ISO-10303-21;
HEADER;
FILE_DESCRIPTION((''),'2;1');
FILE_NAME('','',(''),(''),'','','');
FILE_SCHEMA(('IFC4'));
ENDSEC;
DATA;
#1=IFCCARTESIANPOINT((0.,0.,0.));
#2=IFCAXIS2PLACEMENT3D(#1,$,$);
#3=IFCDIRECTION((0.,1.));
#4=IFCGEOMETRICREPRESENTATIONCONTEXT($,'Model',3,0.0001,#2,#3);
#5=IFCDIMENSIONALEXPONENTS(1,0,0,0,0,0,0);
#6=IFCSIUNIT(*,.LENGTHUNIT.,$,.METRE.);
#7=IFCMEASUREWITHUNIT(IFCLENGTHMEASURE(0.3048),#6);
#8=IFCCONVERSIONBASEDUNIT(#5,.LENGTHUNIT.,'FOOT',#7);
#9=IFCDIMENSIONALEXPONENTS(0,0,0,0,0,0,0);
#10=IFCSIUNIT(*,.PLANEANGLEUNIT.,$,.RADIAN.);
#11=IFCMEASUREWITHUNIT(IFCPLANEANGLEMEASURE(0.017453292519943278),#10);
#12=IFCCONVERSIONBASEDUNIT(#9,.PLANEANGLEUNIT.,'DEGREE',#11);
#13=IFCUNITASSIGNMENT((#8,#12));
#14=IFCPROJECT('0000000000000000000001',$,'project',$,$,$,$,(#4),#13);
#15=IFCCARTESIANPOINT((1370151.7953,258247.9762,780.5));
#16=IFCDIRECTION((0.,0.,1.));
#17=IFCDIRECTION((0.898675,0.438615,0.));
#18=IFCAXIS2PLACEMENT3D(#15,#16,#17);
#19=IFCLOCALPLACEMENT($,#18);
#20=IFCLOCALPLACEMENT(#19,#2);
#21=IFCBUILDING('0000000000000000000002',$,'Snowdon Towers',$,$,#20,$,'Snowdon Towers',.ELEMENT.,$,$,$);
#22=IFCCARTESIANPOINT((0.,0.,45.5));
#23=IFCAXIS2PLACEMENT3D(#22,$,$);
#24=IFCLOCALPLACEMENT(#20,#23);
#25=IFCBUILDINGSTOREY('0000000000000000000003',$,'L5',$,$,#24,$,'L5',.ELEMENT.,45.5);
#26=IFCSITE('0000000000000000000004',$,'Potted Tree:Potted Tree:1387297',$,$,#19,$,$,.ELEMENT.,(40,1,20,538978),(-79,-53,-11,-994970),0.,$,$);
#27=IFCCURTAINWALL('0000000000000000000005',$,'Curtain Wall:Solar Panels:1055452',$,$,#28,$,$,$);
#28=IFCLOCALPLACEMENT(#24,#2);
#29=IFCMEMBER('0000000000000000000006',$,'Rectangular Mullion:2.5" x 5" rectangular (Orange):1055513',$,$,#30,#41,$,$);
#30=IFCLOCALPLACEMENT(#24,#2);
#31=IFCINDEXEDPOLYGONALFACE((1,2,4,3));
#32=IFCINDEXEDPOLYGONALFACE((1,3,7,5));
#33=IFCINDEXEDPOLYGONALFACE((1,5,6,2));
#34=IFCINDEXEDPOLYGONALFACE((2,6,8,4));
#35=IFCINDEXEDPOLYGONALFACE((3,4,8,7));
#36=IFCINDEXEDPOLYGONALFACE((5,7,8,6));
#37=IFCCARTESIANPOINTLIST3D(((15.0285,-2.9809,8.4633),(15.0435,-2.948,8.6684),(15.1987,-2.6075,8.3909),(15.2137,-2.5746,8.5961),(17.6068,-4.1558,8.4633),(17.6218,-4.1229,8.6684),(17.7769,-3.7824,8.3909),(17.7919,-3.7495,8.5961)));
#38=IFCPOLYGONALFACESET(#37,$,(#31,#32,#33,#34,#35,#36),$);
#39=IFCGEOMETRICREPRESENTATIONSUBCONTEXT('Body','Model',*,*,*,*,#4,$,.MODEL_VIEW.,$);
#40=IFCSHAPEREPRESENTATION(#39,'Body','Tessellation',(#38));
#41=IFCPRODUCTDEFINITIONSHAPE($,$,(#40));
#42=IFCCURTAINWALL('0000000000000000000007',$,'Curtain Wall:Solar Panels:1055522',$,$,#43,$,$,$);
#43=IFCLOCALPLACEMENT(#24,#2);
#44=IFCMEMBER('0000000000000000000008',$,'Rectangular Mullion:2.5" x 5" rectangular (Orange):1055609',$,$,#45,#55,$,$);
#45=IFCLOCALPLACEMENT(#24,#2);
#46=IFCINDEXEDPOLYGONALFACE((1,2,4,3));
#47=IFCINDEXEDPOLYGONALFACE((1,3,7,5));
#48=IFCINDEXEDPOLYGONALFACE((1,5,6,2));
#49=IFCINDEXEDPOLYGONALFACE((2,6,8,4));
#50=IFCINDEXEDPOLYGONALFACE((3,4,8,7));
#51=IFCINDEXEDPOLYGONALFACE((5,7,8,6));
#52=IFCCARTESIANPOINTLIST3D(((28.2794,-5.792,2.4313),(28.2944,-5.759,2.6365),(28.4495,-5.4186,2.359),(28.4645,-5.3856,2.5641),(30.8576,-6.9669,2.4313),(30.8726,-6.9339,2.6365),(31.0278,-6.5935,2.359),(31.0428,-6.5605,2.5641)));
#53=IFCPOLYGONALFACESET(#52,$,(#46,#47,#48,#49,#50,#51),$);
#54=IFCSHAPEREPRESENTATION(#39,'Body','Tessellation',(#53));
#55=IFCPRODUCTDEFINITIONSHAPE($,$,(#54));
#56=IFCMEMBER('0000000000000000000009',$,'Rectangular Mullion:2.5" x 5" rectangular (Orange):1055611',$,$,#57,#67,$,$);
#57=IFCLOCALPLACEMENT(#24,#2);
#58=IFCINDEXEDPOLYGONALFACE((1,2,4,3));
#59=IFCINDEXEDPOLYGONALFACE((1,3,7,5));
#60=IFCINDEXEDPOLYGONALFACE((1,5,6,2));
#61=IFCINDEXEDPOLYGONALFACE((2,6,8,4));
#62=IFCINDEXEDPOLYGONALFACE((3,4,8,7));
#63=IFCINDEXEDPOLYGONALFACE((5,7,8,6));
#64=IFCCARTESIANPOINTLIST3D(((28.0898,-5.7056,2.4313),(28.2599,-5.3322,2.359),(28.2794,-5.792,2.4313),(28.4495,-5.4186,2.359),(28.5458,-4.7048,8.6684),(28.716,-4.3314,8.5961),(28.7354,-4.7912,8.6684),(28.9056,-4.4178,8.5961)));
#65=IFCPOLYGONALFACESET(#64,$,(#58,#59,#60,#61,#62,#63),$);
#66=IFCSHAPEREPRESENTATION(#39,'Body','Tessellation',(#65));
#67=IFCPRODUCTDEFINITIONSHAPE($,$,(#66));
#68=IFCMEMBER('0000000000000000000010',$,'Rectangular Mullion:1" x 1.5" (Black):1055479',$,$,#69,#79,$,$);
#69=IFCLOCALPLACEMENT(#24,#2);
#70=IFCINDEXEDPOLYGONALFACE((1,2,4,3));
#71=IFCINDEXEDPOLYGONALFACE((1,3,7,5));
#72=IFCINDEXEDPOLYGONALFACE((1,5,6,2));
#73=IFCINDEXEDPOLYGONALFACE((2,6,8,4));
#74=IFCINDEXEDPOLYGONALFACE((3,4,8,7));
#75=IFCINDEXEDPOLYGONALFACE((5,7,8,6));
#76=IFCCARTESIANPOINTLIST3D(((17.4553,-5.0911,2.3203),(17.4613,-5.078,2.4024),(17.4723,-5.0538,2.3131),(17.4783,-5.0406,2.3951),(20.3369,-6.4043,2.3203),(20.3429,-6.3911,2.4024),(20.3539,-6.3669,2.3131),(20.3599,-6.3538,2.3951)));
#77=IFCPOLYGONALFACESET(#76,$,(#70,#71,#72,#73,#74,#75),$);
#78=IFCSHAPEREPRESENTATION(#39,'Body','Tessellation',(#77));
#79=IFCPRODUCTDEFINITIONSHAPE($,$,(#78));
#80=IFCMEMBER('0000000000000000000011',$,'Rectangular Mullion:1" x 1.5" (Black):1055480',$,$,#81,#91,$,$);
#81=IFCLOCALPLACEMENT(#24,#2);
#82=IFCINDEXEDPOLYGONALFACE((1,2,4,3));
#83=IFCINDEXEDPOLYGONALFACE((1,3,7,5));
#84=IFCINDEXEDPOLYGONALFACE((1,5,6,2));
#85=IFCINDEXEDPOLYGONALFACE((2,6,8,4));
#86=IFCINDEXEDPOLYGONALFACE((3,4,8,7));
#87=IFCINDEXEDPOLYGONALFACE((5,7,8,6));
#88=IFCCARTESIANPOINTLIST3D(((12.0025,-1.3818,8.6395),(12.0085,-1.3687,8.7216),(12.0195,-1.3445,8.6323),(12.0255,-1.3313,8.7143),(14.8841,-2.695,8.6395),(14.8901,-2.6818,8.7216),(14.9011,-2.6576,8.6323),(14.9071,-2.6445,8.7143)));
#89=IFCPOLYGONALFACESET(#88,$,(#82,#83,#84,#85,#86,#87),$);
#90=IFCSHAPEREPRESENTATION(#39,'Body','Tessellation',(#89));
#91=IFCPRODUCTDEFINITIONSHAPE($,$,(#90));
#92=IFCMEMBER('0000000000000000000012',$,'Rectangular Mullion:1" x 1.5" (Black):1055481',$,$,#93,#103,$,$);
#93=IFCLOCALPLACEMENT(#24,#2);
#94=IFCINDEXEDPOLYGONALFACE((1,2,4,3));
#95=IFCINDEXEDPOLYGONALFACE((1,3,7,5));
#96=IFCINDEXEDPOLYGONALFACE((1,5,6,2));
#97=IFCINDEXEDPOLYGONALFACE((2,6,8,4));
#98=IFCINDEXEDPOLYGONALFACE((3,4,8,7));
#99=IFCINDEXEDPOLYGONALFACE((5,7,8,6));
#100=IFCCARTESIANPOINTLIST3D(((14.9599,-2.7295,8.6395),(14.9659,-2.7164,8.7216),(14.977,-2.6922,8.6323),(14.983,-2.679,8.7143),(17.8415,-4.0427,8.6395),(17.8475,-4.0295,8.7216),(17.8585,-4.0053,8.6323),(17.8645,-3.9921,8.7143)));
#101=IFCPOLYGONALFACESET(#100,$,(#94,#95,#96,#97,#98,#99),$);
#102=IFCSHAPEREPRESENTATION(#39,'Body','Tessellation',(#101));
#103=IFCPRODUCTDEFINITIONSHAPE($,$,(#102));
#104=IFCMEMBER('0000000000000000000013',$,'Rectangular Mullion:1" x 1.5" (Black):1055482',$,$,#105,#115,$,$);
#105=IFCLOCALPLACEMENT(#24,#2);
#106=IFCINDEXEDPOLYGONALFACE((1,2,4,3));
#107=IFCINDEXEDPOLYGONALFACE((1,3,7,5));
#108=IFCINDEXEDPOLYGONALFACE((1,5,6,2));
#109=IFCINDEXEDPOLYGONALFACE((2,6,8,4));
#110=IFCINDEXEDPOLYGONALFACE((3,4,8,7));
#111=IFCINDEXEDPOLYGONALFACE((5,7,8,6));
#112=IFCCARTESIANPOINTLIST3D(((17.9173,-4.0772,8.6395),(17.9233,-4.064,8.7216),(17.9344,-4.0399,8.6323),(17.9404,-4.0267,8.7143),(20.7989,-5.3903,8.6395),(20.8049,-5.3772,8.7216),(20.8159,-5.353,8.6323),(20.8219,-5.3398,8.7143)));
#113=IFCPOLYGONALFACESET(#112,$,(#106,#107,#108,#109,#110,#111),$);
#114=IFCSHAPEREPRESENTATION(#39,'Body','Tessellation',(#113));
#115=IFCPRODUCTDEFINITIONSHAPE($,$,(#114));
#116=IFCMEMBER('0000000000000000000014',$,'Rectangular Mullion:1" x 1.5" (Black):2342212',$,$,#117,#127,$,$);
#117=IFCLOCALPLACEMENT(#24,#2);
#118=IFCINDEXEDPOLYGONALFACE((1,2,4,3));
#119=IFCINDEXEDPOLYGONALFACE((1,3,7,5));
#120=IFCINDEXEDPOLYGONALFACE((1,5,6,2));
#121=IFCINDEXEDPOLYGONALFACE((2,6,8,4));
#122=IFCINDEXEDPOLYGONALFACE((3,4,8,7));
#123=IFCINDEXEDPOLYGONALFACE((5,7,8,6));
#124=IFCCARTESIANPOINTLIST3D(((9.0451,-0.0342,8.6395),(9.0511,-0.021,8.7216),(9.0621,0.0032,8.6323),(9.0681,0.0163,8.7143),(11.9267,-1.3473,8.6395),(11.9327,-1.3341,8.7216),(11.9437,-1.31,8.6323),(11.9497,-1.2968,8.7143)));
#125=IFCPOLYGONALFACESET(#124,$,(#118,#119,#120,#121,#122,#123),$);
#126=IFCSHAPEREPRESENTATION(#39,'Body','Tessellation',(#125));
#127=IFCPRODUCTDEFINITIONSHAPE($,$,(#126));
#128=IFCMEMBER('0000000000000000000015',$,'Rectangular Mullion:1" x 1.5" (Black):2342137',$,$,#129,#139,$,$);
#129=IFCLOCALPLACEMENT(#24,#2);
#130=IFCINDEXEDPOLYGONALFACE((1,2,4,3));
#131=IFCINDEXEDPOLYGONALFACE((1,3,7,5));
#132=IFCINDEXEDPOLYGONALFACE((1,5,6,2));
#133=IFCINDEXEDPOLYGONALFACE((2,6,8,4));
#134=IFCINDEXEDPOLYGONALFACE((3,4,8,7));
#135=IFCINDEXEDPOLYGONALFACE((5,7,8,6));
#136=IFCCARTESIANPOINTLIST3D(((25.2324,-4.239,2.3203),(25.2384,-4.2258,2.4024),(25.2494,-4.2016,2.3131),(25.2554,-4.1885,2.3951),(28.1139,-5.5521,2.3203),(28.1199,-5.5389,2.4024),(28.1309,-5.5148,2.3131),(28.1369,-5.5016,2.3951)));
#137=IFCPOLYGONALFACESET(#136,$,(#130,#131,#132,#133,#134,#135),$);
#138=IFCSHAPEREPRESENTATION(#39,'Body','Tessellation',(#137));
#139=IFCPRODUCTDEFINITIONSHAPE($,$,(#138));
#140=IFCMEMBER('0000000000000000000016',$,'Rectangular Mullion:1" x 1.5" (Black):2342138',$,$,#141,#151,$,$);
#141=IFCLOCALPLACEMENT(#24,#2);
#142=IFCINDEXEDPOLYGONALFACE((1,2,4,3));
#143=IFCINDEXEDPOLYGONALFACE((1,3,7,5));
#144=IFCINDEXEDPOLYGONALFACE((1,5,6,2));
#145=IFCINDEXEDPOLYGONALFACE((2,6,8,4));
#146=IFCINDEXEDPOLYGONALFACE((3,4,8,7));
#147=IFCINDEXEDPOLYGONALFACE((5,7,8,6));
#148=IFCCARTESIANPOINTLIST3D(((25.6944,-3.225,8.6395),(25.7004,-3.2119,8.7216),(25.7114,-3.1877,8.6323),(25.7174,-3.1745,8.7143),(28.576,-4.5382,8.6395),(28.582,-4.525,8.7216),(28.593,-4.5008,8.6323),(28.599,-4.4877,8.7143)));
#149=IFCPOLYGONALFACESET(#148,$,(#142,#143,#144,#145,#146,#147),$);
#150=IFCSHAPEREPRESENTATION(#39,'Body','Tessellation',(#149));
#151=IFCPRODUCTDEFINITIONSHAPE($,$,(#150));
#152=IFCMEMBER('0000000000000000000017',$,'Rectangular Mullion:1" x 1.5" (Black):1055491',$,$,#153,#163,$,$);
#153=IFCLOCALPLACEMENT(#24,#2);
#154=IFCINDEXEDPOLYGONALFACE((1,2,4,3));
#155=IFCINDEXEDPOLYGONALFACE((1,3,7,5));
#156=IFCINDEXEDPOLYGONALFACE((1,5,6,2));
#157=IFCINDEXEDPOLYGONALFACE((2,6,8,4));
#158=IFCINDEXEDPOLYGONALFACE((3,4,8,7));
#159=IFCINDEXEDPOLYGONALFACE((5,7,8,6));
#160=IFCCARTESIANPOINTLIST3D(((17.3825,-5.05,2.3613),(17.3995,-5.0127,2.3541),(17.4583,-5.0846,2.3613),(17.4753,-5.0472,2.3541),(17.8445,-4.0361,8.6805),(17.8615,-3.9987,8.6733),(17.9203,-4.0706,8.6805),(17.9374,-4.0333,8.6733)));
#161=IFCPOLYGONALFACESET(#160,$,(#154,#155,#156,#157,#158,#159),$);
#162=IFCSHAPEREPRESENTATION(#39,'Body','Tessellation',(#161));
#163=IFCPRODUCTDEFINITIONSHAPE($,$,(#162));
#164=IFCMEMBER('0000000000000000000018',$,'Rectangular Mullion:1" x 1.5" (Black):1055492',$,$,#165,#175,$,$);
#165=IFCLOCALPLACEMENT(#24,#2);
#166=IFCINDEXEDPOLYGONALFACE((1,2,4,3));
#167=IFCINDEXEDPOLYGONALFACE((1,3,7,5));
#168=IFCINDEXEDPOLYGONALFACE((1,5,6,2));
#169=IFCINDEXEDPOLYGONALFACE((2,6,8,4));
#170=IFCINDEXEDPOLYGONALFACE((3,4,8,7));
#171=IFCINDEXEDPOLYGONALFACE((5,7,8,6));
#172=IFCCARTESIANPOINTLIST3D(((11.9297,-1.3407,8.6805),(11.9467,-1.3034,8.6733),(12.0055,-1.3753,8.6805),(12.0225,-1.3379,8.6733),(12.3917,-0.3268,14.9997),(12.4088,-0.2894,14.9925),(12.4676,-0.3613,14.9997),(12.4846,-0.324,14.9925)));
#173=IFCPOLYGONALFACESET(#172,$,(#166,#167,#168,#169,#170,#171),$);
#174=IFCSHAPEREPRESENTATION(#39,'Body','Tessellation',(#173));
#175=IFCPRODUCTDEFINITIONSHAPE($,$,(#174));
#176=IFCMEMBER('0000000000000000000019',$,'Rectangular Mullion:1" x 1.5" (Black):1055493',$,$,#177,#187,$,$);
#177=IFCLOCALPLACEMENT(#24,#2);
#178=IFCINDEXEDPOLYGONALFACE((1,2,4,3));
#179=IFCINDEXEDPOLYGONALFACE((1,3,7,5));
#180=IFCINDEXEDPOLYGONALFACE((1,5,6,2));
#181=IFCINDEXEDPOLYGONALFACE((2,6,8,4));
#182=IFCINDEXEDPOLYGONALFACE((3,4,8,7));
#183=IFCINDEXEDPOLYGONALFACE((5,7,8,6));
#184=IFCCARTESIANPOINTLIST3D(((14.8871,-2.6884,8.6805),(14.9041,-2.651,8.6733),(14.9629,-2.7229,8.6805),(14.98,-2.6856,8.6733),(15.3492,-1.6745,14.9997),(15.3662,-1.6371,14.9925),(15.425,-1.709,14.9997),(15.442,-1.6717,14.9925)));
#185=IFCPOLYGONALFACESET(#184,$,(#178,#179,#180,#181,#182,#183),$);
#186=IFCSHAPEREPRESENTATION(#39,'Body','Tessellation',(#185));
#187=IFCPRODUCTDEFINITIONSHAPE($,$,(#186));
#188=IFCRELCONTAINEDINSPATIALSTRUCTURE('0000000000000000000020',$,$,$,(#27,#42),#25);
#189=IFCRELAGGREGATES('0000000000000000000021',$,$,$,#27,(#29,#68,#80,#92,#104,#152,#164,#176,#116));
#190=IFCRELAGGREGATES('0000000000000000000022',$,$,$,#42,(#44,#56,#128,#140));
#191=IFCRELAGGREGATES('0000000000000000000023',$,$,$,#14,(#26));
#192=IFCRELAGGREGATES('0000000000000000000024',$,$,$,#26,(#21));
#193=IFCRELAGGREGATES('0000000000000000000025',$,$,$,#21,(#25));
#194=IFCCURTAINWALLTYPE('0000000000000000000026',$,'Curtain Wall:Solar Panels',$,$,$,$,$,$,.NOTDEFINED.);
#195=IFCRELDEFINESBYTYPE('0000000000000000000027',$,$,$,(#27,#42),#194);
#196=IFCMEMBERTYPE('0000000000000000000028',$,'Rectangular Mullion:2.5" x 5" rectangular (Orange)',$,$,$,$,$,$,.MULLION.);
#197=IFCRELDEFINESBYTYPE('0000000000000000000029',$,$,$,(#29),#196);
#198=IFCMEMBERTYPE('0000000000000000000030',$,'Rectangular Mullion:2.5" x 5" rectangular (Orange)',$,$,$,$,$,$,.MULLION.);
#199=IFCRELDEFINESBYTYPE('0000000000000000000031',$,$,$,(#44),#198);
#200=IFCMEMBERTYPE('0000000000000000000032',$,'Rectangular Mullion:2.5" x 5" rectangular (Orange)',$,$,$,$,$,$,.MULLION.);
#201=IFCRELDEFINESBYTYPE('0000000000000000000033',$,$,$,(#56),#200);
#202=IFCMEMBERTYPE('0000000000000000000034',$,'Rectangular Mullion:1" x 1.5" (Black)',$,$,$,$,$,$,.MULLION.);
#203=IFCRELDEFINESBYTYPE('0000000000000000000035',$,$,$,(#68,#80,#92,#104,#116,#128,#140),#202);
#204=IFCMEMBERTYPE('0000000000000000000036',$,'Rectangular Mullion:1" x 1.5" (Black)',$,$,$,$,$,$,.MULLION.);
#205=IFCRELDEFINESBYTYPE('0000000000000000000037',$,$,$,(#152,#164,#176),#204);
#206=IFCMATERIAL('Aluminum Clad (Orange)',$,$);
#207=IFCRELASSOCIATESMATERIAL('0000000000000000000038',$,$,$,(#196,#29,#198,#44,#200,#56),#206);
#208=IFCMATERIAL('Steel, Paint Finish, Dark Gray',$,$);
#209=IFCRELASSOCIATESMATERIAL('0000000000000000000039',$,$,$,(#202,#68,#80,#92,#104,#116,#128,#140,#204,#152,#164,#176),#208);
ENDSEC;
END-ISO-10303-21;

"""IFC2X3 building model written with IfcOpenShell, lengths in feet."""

from ifc_helpers import new_model, entity, si_unit, converted_unit, direction, frame, frame_2d, origin, origin_2d_with_axis, place, context, subcontext, project, spatial, rectangle, extrude, source, transform, mapped, material, type_object, type_shapes, element, aggregate, save


model = new_model("IFC2X3")

# Units and contexts
model_context = context("Model", 3, precision=0.0001, world=origin(), true_north=direction((0.0, 1.0)))
body_context = subcontext(model_context, "Body", "Model", "MODEL_VIEW")
ifc_project = project(units=[converted_unit("LENGTHUNIT", "FOOT", entity("IfcLengthMeasure", 0.3048), si_unit("LENGTHUNIT", "METRE"), dimensions=[1, 0, 0, 0, 0, 0, 0]), converted_unit("PLANEANGLEUNIT", "DEGREE", entity("IfcPlaneAngleMeasure", 0.017453292519943278), si_unit("PLANEANGLEUNIT", "RADIAN"), dimensions=[0, 0, 0, 0, 0, 0, 0])], contexts=[model_context])

# Site, building, storey
site_placement = place(None, frame((1370151.7953, 258247.9762, 780.5), z_axis=(0.0, 0.0, 1.0), x_axis=(0.898675, 0.438615, 0.0)))
site = spatial("IfcSite", under=ifc_project, at=site_placement, Name="Potted Tree:Potted Tree:1387297", CompositionType="ELEMENT", RefLatitude=(40, 1, 20, 538978), RefLongitude=(-79, -53, -11, -994970), RefElevation=0.0)
building_placement = place(site_placement, origin())
building = spatial("IfcBuilding", under=site, at=building_placement, Name="Snowdon Towers", LongName="Snowdon Towers", CompositionType="ELEMENT")
storey_placement = place(building_placement, frame((0.0, 0.0, 45.5)))
storey = spatial("IfcBuildingStorey", under=building, at=storey_placement, Name="L5", LongName="L5", CompositionType="ELEMENT", Elevation=45.5)

# Curtain wall, member
curtain_wall_type = type_object("IfcCurtainWallType", Name="Curtain Wall:Solar Panels", PredefinedType="NOTDEFINED")
curtain_wall_1_placement = place(storey_placement, frame((0.0, 0.0, -45.5)))
curtain_wall_1 = element("IfcCurtainWall", 1, at=curtain_wall_1_placement, inside=storey, type_object=curtain_wall_type, Name="Curtain Wall:Solar Panels:1055452")
ifc_material_1 = material(Name="Aluminum Clad (Orange)")
member_type_1 = type_object("IfcMemberType", Name="Rectangular Mullion:2.5\" x 5\" rectangular (Orange)", PredefinedType="MULLION", material=ifc_material_1)
shared_shape_1 = source(origin(), body_context, "Body", "SweptSolid", [
    extrude(rectangle(XDim=0.2083, YDim=0.4167, at=frame_2d((0.0, 0.0), x_axis=(1.0, 0.0))), frame((-0.1042, 0.0, -2.8333), z_axis=(0.0, 0.0, 1.0), x_axis=(-1.0, 0.0, 0.0)), (0.0, 0.0, 1.0), 2.8333),
])
type_shapes(member_type_1, [shared_shape_1])
member_1_placement = place(curtain_wall_1_placement, frame((17.7069, -3.9362, 54.1323), z_axis=(0.909972, -0.414671, 0.0), x_axis=(0.072007, 0.158015, 0.984808)))
member_1 = element("IfcMember", 2, at=member_1_placement, type_object=member_type_1, material=ifc_material_1, Name="Rectangular Mullion:2.5\" x 5\" rectangular (Orange):1055513", context=body_context, shape_type="MappedRepresentation", body=[
    mapped(shared_shape_1, transform((0.0, 0.0, 0.0), scale=1.0)),
])

# Curtain wall, members
curtain_wall_2_placement = place(storey_placement, frame((0.0, 0.0, -45.5)))
curtain_wall_2 = element("IfcCurtainWall", 3, at=curtain_wall_2_placement, inside=storey, type_object=curtain_wall_type, Name="Curtain Wall:Solar Panels:1055522")
member_type_2 = type_object("IfcMemberType", Name="Rectangular Mullion:2.5\" x 5\" rectangular (Orange)", PredefinedType="MULLION", material=ifc_material_1)
shared_shape_2 = source(origin(), body_context, "Body", "SweptSolid", [
    extrude(rectangle(XDim=0.2083, YDim=0.4167, at=frame_2d((0.0, 0.0), x_axis=(1.0, 0.0))), frame((-0.1042, 0.0, -2.8333), z_axis=(0.0, 0.0, 1.0), x_axis=(-1.0, 0.0, 0.0)), (0.0, 0.0, 1.0), 2.8333),
])
type_shapes(member_type_2, [shared_shape_2])
member_2_placement = place(curtain_wall_2_placement, frame((28.3644, -5.6053, 47.8951), z_axis=(-0.909972, 0.414671, 0.0), x_axis=(-0.072007, -0.158015, -0.984808)))
member_2 = element("IfcMember", 4, at=member_2_placement, type_object=member_type_2, material=ifc_material_1, Name="Rectangular Mullion:2.5\" x 5\" rectangular (Orange):1055609", context=body_context, shape_type="MappedRepresentation", body=[
    mapped(shared_shape_2, transform((0.0, 0.0, 0.0), scale=1.0)),
])
member_type_3 = type_object("IfcMemberType", Name="Rectangular Mullion:2.5\" x 5\" rectangular (Orange)", PredefinedType="MULLION", material=ifc_material_1)
shared_shape_3 = source(origin(), body_context, "Body", "SweptSolid", [
    extrude(rectangle(XDim=0.2083, YDim=0.4167, at=frame_2d((0.0, 0.0), x_axis=(1.0, 0.0))), frame((-0.1042, 0.0, -6.3333), z_axis=(0.0, 0.0, 1.0), x_axis=(-1.0, 0.0, 0.0)), (0.0, 0.0, 1.0), 6.3333),
])
type_shapes(member_type_3, [shared_shape_3])
member_3_placement = place(curtain_wall_2_placement, frame((28.6309, -4.5181, 54.1323), z_axis=(0.072007, 0.158015, 0.984808), x_axis=(-0.909972, 0.414671, 0.0)))
member_3 = element("IfcMember", 5, at=member_3_placement, type_object=member_type_3, material=ifc_material_1, Name="Rectangular Mullion:2.5\" x 5\" rectangular (Orange):1055611", context=body_context, shape_type="MappedRepresentation", body=[
    mapped(shared_shape_3, transform((0.0, 0.0, 0.0), scale=1.0)),
])

# Members
ifc_material_2 = material(Name="Steel, Paint Finish, Dark Gray")
member_type_4 = type_object("IfcMemberType", Name="Rectangular Mullion:1\" x 1.5\" (Black)", PredefinedType="MULLION", material=ifc_material_2)
shared_shape_4 = source(origin(), body_context, "Body", "SweptSolid", [
    extrude(rectangle(XDim=0.0833, YDim=0.0417, at=origin_2d_with_axis()), frame((0.0, 0.0208, -3.1667), z_axis=(0.0, 0.0, 1.0), x_axis=(-1.0, 0.0, 0.0)), (0.0, 0.0, 1.0), 3.1667),
])
type_shapes(member_type_4, [shared_shape_4])
member_4_placement = place(curtain_wall_1_placement, frame((20.3569, -6.3603, 47.8541), z_axis=(0.909972, -0.414671, 0.0), x_axis=(0.072007, 0.158015, 0.984808)))
member_4 = element("IfcMember", 6, at=member_4_placement, type_object=member_type_4, material=ifc_material_2, Name="Rectangular Mullion:1\" x 1.5\" (Black):1055479", context=body_context, shape_type="MappedRepresentation", body=[
    mapped(shared_shape_4, transform((0.0, 0.0, 0.0), scale=1.0)),
])
member_5_placement = place(curtain_wall_1_placement, frame((14.9041, -2.651, 54.1733), z_axis=(0.909972, -0.414671, 0.0), x_axis=(0.072007, 0.158015, 0.984808)))
member_5 = element("IfcMember", 7, at=member_5_placement, type_object=member_type_4, material=ifc_material_2, Name="Rectangular Mullion:1\" x 1.5\" (Black):1055480", context=body_context, shape_type="MappedRepresentation", body=[
    mapped(shared_shape_4, transform((0.0, 0.0, 0.0), scale=1.0)),
])
member_6_placement = place(curtain_wall_1_placement, frame((17.8615, -3.9987, 54.1733), z_axis=(0.909972, -0.414671, 0.0), x_axis=(0.072007, 0.158015, 0.984808)))
member_6 = element("IfcMember", 8, at=member_6_placement, type_object=member_type_4, material=ifc_material_2, Name="Rectangular Mullion:1\" x 1.5\" (Black):1055481", context=body_context, shape_type="MappedRepresentation", body=[
    mapped(shared_shape_4, transform((0.0, 0.0, 0.0), scale=1.0)),
])
member_7_placement = place(curtain_wall_1_placement, frame((20.8189, -5.3464, 54.1733), z_axis=(0.909972, -0.414671, 0.0), x_axis=(0.072007, 0.158015, 0.984808)))
member_7 = element("IfcMember", 9, at=member_7_placement, type_object=member_type_4, material=ifc_material_2, Name="Rectangular Mullion:1\" x 1.5\" (Black):1055482", context=body_context, shape_type="MappedRepresentation", body=[
    mapped(shared_shape_4, transform((0.0, 0.0, 0.0), scale=1.0)),
])
member_8_placement = place(curtain_wall_1_placement, frame((11.9467, -1.3034, 54.1733), z_axis=(0.909972, -0.414671, 0.0), x_axis=(0.072007, 0.158015, 0.984808)))
member_8 = element("IfcMember", 10, at=member_8_placement, type_object=member_type_4, material=ifc_material_2, Name="Rectangular Mullion:1\" x 1.5\" (Black):2342212", context=body_context, shape_type="MappedRepresentation", body=[
    mapped(shared_shape_4, transform((0.0, 0.0, 0.0), scale=1.0)),
])
member_9_placement = place(curtain_wall_2_placement, frame((28.1339, -5.5082, 47.8541), z_axis=(0.909972, -0.414671, 0.0), x_axis=(0.072007, 0.158015, 0.984808)))
member_9 = element("IfcMember", 11, at=member_9_placement, type_object=member_type_4, material=ifc_material_2, Name="Rectangular Mullion:1\" x 1.5\" (Black):2342137", context=body_context, shape_type="MappedRepresentation", body=[
    mapped(shared_shape_4, transform((0.0, 0.0, 0.0), scale=1.0)),
])
member_10_placement = place(curtain_wall_2_placement, frame((28.596, -4.4943, 54.1733), z_axis=(0.909972, -0.414671, 0.0), x_axis=(0.072007, 0.158015, 0.984808)))
member_10 = element("IfcMember", 12, at=member_10_placement, type_object=member_type_4, material=ifc_material_2, Name="Rectangular Mullion:1\" x 1.5\" (Black):2342138", context=body_context, shape_type="MappedRepresentation", body=[
    mapped(shared_shape_4, transform((0.0, 0.0, 0.0), scale=1.0)),
])
member_type_5 = type_object("IfcMemberType", Name="Rectangular Mullion:1\" x 1.5\" (Black)", PredefinedType="MULLION", material=ifc_material_2)
shared_shape_5 = source(origin(), body_context, "Body", "SweptSolid", [
    extrude(rectangle(XDim=0.0833, YDim=0.0417, at=origin_2d_with_axis()), frame((0.0, 0.0208, -6.4167), z_axis=(0.0, 0.0, 1.0), x_axis=(-1.0, 0.0, 0.0)), (0.0, 0.0, 1.0), 6.4167),
])
type_shapes(member_type_5, [shared_shape_5])
member_11_placement = place(curtain_wall_1_placement, frame((17.4374, -5.0299, 47.8541), z_axis=(-0.072007, -0.158015, -0.984808), x_axis=(0.909972, -0.414671, 0.0)))
member_11 = element("IfcMember", 13, at=member_11_placement, type_object=member_type_5, material=ifc_material_2, Name="Rectangular Mullion:1\" x 1.5\" (Black):1055491", context=body_context, shape_type="MappedRepresentation", body=[
    mapped(shared_shape_5, transform((0.0, 0.0, 0.0), scale=1.0)),
])
member_12_placement = place(curtain_wall_1_placement, frame((11.9846, -1.3206, 54.1733), z_axis=(-0.072007, -0.158015, -0.984808), x_axis=(0.909972, -0.414671, 0.0)))
member_12 = element("IfcMember", 14, at=member_12_placement, type_object=member_type_5, material=ifc_material_2, Name="Rectangular Mullion:1\" x 1.5\" (Black):1055492", context=body_context, shape_type="MappedRepresentation", body=[
    mapped(shared_shape_5, transform((0.0, 0.0, 0.0), scale=1.0)),
])
member_13_placement = place(curtain_wall_1_placement, frame((14.942, -2.6683, 54.1733), z_axis=(-0.072007, -0.158015, -0.984808), x_axis=(0.909972, -0.414671, 0.0)))
member_13 = element("IfcMember", 15, at=member_13_placement, type_object=member_type_5, material=ifc_material_2, Name="Rectangular Mullion:1\" x 1.5\" (Black):1055493", context=body_context, shape_type="MappedRepresentation", body=[
    mapped(shared_shape_5, transform((0.0, 0.0, 0.0), scale=1.0)),
])

aggregate(curtain_wall_1, [member_1, member_4, member_5, member_6, member_7, member_11, member_12, member_13, member_8])
aggregate(curtain_wall_2, [member_2, member_3, member_9, member_10])

save(model, "model.ifc")
